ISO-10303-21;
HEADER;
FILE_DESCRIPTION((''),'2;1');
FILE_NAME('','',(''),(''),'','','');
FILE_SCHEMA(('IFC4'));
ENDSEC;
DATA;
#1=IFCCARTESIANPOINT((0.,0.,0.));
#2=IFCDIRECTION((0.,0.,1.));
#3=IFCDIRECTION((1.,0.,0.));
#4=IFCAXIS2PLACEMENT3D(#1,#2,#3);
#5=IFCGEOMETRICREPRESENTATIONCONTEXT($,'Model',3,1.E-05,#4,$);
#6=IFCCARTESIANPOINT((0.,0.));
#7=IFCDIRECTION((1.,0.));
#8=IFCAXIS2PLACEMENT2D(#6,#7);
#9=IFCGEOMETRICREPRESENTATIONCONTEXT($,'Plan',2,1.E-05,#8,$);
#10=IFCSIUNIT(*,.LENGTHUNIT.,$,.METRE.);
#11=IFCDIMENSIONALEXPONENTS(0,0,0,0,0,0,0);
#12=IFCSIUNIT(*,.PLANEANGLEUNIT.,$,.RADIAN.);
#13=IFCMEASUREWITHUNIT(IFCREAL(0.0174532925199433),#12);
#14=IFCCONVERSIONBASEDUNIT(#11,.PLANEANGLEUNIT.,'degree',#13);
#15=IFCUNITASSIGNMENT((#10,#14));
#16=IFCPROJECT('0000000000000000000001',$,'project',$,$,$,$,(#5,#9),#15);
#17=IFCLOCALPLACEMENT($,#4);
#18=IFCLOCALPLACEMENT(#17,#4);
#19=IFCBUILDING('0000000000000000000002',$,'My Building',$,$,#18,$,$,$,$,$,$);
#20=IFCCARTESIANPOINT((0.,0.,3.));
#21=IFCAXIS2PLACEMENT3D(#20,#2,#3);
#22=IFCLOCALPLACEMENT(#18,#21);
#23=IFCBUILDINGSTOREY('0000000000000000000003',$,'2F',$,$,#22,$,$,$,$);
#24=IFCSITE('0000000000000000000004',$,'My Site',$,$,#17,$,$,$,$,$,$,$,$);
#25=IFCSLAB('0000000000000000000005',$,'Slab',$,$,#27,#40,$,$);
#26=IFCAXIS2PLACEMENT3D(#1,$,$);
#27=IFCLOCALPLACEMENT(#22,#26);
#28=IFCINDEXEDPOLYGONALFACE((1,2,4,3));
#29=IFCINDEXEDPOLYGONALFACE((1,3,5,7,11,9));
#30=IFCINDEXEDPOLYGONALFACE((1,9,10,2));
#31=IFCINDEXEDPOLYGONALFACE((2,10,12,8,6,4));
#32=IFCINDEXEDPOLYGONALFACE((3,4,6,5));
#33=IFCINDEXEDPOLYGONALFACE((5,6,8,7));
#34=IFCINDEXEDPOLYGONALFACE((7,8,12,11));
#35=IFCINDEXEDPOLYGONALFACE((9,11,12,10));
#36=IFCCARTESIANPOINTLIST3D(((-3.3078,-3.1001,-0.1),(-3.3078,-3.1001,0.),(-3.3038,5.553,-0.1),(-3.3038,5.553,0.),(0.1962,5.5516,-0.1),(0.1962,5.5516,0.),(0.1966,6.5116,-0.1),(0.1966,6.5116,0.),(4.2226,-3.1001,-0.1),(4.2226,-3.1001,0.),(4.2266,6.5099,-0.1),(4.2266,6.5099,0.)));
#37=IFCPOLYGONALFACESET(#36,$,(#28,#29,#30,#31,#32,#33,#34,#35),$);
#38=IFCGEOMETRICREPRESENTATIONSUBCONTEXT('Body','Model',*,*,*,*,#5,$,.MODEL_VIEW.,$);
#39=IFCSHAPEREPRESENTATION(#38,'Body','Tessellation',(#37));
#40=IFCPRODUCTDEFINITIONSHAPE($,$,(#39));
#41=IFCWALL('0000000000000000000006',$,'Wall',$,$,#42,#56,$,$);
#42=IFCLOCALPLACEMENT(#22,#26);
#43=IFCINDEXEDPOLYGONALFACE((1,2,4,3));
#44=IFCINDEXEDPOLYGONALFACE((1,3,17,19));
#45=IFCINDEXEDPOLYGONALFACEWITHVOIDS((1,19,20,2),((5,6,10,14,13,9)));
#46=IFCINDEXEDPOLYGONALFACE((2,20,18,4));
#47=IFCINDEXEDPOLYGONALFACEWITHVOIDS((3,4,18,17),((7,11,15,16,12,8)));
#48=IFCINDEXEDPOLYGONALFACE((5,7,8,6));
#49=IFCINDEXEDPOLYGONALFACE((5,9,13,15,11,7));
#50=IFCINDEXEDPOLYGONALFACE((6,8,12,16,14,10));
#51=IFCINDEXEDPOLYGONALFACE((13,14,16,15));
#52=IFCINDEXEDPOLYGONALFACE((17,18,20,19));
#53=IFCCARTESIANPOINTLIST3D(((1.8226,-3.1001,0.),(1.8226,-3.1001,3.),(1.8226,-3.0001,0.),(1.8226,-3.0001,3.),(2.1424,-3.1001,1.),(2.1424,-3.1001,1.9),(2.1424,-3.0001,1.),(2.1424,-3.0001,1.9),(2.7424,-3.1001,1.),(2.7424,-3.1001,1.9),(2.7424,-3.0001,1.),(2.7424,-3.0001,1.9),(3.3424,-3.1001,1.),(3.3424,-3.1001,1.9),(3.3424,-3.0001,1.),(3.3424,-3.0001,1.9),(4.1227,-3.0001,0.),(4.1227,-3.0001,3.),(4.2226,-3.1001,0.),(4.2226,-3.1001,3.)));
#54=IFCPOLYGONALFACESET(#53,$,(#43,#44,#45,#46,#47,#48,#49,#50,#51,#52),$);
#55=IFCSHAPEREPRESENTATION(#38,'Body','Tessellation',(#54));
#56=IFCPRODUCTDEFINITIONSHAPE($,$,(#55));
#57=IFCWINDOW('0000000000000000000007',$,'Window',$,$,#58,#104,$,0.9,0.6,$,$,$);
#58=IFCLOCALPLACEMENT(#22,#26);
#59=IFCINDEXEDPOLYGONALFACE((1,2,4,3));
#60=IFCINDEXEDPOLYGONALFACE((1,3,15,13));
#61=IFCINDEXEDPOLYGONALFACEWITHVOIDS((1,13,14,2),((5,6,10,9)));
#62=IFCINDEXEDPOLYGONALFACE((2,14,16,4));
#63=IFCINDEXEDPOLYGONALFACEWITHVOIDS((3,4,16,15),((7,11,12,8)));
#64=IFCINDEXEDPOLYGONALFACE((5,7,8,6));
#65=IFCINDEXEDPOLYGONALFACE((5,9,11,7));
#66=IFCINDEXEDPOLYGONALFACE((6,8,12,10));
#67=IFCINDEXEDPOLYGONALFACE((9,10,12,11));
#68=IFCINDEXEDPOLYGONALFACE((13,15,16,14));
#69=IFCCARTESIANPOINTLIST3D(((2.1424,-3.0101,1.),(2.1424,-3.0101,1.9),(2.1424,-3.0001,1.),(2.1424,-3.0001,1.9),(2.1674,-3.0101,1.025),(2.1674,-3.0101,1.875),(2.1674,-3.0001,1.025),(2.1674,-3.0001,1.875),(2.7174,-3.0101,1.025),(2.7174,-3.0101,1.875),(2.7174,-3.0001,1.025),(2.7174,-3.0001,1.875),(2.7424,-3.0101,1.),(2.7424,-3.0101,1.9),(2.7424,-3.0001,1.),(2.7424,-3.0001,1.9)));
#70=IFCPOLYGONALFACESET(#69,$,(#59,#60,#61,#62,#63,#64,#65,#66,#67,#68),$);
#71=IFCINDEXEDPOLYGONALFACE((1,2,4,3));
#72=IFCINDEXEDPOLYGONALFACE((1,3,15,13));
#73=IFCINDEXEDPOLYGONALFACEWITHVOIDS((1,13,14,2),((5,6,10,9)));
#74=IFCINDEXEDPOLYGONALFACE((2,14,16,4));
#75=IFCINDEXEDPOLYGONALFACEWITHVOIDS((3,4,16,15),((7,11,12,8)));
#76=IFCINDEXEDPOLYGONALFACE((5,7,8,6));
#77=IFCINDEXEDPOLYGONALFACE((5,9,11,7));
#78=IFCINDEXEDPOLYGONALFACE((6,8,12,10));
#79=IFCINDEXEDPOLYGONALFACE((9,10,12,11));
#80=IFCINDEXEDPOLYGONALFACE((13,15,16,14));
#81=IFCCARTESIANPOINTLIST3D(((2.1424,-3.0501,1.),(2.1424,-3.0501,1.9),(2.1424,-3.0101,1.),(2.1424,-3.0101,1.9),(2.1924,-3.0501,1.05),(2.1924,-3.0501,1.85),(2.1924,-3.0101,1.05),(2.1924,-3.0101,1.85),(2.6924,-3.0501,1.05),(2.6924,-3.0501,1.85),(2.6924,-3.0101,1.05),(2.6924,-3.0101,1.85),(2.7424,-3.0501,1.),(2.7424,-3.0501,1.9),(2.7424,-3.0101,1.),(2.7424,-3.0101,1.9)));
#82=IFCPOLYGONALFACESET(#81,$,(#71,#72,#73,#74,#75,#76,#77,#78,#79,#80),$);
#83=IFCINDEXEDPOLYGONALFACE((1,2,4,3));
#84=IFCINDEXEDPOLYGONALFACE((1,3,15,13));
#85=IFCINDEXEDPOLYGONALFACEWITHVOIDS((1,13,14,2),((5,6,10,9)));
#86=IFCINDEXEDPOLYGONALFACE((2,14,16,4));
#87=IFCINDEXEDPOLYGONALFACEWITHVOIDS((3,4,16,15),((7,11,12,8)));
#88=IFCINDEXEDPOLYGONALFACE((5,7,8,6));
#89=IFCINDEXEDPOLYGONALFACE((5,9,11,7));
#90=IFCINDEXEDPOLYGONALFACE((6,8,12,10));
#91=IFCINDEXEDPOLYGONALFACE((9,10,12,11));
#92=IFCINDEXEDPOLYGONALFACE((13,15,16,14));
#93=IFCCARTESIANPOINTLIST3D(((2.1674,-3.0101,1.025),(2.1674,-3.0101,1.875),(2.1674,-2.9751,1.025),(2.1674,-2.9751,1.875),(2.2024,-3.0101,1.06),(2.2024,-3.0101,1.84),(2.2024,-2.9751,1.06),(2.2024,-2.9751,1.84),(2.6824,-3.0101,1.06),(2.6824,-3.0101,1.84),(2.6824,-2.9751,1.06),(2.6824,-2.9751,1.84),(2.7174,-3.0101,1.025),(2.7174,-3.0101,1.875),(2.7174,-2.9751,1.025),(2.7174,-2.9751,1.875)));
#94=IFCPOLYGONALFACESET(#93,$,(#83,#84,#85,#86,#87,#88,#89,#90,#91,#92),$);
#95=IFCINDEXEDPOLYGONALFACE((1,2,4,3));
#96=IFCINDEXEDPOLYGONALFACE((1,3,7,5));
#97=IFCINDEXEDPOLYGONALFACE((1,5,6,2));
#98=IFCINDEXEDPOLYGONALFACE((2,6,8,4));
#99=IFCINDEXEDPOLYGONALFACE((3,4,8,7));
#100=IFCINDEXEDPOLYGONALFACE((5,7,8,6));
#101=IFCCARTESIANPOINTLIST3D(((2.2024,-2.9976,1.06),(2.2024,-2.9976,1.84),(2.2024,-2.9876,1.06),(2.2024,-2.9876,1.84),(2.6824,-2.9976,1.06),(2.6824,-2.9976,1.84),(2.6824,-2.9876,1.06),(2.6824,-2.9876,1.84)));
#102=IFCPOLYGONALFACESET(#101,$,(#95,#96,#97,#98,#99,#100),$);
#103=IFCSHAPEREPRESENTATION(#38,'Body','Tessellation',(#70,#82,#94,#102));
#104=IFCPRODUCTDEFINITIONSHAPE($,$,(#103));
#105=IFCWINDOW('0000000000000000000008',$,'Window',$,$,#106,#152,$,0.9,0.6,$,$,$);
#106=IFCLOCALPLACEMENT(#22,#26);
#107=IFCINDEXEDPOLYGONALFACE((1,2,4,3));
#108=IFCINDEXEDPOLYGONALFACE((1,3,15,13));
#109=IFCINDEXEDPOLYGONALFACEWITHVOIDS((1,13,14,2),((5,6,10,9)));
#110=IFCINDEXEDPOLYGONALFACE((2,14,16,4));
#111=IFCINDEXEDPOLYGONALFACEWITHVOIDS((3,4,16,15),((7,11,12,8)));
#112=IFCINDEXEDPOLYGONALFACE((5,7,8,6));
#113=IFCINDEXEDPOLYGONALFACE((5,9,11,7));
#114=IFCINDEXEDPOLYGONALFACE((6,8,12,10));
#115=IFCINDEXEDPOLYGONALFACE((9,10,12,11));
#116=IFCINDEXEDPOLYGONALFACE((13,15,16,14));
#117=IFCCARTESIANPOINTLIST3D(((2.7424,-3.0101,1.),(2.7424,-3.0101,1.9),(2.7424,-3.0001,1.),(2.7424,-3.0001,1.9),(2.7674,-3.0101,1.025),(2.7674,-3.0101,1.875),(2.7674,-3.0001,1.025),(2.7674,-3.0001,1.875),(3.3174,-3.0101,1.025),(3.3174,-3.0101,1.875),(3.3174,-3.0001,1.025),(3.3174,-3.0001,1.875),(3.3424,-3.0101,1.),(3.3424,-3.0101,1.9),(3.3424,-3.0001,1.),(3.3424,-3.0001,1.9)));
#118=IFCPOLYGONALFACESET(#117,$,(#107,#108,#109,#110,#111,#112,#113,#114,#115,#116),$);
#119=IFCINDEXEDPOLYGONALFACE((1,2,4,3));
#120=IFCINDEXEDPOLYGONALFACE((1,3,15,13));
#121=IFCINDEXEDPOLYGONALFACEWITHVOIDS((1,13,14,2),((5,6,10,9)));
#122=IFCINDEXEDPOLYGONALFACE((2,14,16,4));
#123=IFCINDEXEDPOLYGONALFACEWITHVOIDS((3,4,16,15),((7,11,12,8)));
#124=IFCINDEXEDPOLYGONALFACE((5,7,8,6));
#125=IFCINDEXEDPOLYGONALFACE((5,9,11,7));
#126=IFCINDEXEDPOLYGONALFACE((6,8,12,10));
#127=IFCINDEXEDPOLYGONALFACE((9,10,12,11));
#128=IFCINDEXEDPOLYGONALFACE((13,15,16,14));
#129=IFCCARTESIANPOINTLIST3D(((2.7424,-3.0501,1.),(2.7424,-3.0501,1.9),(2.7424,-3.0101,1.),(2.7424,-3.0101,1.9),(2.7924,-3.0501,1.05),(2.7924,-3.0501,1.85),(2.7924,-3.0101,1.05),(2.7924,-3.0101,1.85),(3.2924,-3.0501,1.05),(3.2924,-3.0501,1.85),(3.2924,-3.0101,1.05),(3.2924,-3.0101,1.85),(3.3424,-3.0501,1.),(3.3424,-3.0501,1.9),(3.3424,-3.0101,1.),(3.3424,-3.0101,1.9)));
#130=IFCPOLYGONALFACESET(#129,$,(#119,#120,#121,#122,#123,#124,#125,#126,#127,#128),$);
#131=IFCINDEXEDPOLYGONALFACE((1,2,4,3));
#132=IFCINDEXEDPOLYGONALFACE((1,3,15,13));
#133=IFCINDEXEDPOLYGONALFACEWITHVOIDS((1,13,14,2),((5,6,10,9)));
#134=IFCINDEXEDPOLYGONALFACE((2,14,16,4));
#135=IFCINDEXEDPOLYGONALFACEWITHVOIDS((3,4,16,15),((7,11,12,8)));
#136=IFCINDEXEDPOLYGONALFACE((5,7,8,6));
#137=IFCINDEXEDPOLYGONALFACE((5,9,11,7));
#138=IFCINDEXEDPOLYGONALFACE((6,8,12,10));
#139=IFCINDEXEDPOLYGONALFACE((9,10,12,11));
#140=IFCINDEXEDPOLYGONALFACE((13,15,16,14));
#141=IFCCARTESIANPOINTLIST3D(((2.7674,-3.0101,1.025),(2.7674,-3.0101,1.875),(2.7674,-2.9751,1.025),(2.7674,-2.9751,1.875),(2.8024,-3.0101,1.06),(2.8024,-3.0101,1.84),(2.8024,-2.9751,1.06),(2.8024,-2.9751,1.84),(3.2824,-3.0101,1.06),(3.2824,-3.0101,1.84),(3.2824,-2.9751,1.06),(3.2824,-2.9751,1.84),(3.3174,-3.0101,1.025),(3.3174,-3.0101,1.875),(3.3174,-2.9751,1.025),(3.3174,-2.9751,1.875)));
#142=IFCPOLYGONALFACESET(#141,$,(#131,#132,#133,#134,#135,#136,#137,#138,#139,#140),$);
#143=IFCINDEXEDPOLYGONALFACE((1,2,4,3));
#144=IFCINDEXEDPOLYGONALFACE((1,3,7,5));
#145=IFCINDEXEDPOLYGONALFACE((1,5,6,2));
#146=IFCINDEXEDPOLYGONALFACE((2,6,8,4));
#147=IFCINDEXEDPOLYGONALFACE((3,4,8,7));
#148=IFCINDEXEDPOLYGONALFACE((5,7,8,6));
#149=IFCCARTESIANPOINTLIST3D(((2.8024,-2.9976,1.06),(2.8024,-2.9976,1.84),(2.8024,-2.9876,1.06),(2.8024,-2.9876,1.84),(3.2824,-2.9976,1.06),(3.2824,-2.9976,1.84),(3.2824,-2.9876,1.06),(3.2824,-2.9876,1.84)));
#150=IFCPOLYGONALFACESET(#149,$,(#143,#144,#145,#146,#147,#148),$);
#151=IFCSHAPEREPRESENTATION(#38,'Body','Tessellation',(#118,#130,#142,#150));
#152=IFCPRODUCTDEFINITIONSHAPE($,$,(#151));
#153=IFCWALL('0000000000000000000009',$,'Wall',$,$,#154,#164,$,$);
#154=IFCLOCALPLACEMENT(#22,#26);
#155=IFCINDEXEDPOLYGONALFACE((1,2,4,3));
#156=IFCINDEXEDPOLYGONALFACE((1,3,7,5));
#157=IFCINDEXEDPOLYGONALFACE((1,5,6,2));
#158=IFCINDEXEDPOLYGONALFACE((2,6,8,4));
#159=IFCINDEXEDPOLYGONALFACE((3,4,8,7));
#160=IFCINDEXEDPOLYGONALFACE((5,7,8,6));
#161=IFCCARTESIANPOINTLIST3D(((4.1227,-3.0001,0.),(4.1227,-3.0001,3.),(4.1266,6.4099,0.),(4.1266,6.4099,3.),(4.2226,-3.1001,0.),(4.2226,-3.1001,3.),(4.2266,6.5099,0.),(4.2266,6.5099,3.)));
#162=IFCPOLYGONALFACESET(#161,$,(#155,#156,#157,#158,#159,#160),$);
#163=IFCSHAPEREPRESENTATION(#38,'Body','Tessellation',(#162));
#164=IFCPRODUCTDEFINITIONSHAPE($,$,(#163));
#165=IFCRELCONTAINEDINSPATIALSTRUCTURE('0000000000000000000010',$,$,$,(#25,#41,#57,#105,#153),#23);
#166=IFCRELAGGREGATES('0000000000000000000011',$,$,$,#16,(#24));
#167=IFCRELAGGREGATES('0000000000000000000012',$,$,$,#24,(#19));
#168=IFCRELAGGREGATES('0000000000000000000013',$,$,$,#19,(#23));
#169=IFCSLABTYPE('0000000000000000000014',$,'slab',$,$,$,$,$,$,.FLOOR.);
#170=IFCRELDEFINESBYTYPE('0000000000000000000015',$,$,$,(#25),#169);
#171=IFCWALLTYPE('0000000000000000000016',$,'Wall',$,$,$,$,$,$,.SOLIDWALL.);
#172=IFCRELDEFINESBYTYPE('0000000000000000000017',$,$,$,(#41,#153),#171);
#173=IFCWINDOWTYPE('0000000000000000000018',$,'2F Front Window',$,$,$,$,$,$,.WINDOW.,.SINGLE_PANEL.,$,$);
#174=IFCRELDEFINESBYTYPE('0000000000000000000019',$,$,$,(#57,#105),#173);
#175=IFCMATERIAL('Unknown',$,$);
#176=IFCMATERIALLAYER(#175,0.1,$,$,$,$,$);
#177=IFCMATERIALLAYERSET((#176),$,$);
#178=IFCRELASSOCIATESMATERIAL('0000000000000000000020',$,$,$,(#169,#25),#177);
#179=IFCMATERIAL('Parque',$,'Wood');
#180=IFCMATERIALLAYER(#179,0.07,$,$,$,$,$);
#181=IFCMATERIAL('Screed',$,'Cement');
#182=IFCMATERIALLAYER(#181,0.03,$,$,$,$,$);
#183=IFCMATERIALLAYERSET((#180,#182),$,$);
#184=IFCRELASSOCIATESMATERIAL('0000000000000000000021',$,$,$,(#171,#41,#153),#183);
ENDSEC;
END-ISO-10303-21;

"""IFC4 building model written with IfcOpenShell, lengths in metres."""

from ifc_helpers import new_model, entity, si_unit, converted_unit, frame, origin_with_axes, origin_2d_with_axis, place, context, subcontext, project, spatial, line, indexed_curve, outline, extrude, shape, source, transform, mapped, material, layer, layer_set, layer_usage, type_object, type_shapes, element, fill, save


model = new_model("IFC4")

# Units and contexts
model_context = context("Model", 3, precision=1e-05, world=origin_with_axes())
plan_context = context("Plan", 2, precision=1e-05, world=origin_2d_with_axis())
body_context_1 = subcontext(model_context, "Body", "Model", "MODEL_VIEW")
body_context_2 = subcontext(plan_context, "Body", "Plan", "PLAN_VIEW")
ifc_project = project(units=[si_unit("LENGTHUNIT", "METRE"), converted_unit("PLANEANGLEUNIT", "degree", entity("IfcReal", 0.0174532925199433), si_unit("PLANEANGLEUNIT", "RADIAN"), dimensions=[0, 0, 0, 0, 0, 0, 0])], contexts=[model_context, plan_context])

# Site, building, storey
site_placement = place(None, origin_with_axes())
site = spatial("IfcSite", under=ifc_project, at=site_placement, Name="My Site")
building_placement = place(site_placement, origin_with_axes())
building = spatial("IfcBuilding", under=site, at=building_placement, Name="My Building")
storey_placement = place(building_placement, frame((0.0, 0.0, 3.0), z_axis=(0.0, 0.0, 1.0), x_axis=(1.0, 0.0, 0.0)))
storey = spatial("IfcBuildingStorey", under=building, at=storey_placement, Name="2F")

# Slab
ifc_material_1 = material(Name="Unknown")
ifc_layer_1 = layer(ifc_material_1, 0.1)
ifc_layer_set_1 = layer_set([ifc_layer_1])
ifc_layer_usage_1 = layer_usage(ifc_layer_set_1, "AXIS3", "POSITIVE", -0.1)
slab_type = type_object("IfcSlabType", Name="slab", PredefinedType="FLOOR", material=ifc_layer_set_1)
slab_placement = place(storey_placement, frame((-3.3078, -3.1001, 0.0), z_axis=(0.0, 0.0, 1.0), x_axis=(1.0, 0.0, 0.0)))
element("IfcSlab", 1, at=slab_placement, inside=storey, type_object=slab_type, material=ifc_layer_usage_1, Name="Slab", context=body_context_1, shape_type="SweptSolid", body=[
    extrude(outline(indexed_curve([(0.0, 0.0), (7.5304, 0.0), (7.5344, 9.61), (3.5044, 9.6117), (3.504, 8.6517), (0.004, 8.6531), (0.0, 0.0)])), frame((0.0, 0.0, -0.1), z_axis=(0.0, 0.0, 1.0), x_axis=(1.0, 0.0, 0.0)), (0.0, 0.0, 1.0), 0.1),
])

# Wall, openings, windows
ifc_material_2 = material(Name="Parque", Category="Wood")
ifc_layer_2 = layer(ifc_material_2, 0.07)
ifc_material_3 = material(Name="Screed", Category="Cement")
ifc_layer_3 = layer(ifc_material_3, 0.03)
ifc_layer_set_2 = layer_set([ifc_layer_2, ifc_layer_3])
ifc_layer_usage_2 = layer_usage(ifc_layer_set_2, "AXIS2", "POSITIVE", 0.0)
wall_type = type_object("IfcWallType", Name="Wall", PredefinedType="SOLIDWALL", material=ifc_layer_set_2)
wall_1_placement = place(storey_placement, frame((1.8226, -3.1001, 0.0), z_axis=(0.0, 0.0, 1.0), x_axis=(1.0, 0.0, 0.0)))
wall_1 = element("IfcWall", 2, at=wall_1_placement, inside=storey, type_object=wall_type, material=ifc_layer_usage_2, Name="Wall", context=body_context_1, shape_type="SweptSolid", body=[
    extrude(outline(indexed_curve([(0.0, 0.0), (0.0, 0.1), (2.3, 0.1), (2.4, 0.0)], segments=[line(1, 2, 3, 4, 1)])), origin_with_axes(), (0.0, 0.0, 1.0), 3.0),
])
shared_shape_1 = source(origin_with_axes(), body_context_1, "Body", "SweptSolid", [
    extrude(outline(indexed_curve([(0.0, 0.0), (0.6, 0.0), (0.6, 0.9), (0.0, 0.9)], segments=[line(1, 2, 3, 4, 1)])), frame((0.0, -0.6, 0.0), z_axis=(0.0, -1.0, 0.0), x_axis=(1.0, 0.0, 0.0)), (0.0, 0.0, -1.0), 1.2),
])
opening_1_placement = place(wall_1_placement, frame((0.3197, 0.0, 1.0), z_axis=(0.0, 0.0, 1.0), x_axis=(1.0, 0.0, 0.0)))
opening_1 = element("IfcOpeningElement", 3, at=opening_1_placement, cuts=wall_1, PredefinedType="OPENING", context=body_context_1, shape_type="MappedRepresentation", body=[
    mapped(shared_shape_1, transform((0.0, 0.0, 0.0), x_axis=(1.0, 0.0, 0.0), y_axis=(0.0, 1.0, 0.0), z_axis=(0.0, 0.0, 1.0), scale=1.0)),
])
opening_2_placement = place(wall_1_placement, frame((0.9197, 0.0, 1.0), z_axis=(0.0, 0.0, 1.0), x_axis=(1.0, 0.0, 0.0)))
opening_2 = element("IfcOpeningElement", 4, at=opening_2_placement, cuts=wall_1, PredefinedType="OPENING", context=body_context_1, shape_type="MappedRepresentation", body=[
    mapped(shared_shape_1, transform((0.0, 0.0, 0.0), x_axis=(1.0, 0.0, 0.0), y_axis=(0.0, 1.0, 0.0), z_axis=(0.0, 0.0, 1.0), scale=1.0)),
])
window_type = type_object("IfcWindowType", Name="2F Front Window", PartitioningType="SINGLE_PANEL", PredefinedType="WINDOW")
shared_shape_2 = source(origin_with_axes(), body_context_1, "Body", "SweptSolid", [
    extrude(outline(indexed_curve([(0.0, 0.0), (0.6, 0.0), (0.6, 0.9), (0.0, 0.9)], segments=[line(1, 2, 3, 4, 1)]), holes=[indexed_curve([(0.025, 0.025), (0.575, 0.025), (0.575, 0.875), (0.025, 0.875)], segments=[line(1, 2, 3, 4, 1)])]), frame((0.0, 0.09, 0.0), z_axis=(0.0, -1.0, 0.0), x_axis=(1.0, 0.0, 0.0)), (0.0, 0.0, -1.0), 0.01),
    extrude(outline(indexed_curve([(0.0, 0.0), (0.6, 0.0), (0.6, 0.9), (0.0, 0.9)], segments=[line(1, 2, 3, 4, 1)]), holes=[indexed_curve([(0.05, 0.05), (0.55, 0.05), (0.55, 0.85), (0.05, 0.85)], segments=[line(1, 2, 3, 4, 1)])]), frame((0.0, 0.05, 0.0), z_axis=(0.0, -1.0, 0.0), x_axis=(1.0, 0.0, 0.0)), (0.0, 0.0, -1.0), 0.04),
    extrude(outline(indexed_curve([(0.0, 0.0), (0.55, 0.0), (0.55, 0.85), (0.0, 0.85)], segments=[line(1, 2, 3, 4, 1)]), holes=[indexed_curve([(0.035, 0.035), (0.515, 0.035), (0.515, 0.815), (0.035, 0.815)], segments=[line(1, 2, 3, 4, 1)])]), frame((0.025, 0.09, 0.025), z_axis=(0.0, -1.0, 0.0), x_axis=(1.0, 0.0, 0.0)), (0.0, 0.0, -1.0), 0.035),
    extrude(outline(indexed_curve([(0.035, 0.035), (0.515, 0.035), (0.515, 0.815), (0.035, 0.815)], segments=[line(1, 2, 3, 4, 1)])), frame((0.025, 0.1025, 0.025), z_axis=(0.0, -1.0, 0.0), x_axis=(1.0, 0.0, 0.0)), (0.0, 0.0, -1.0), 0.01),
])
shared_shape_3 = source(origin_with_axes(), body_context_2, "Body", "Curve2D", [
    entity("IfcIndexedPolyCurve", entity("IfcCartesianPointList2D", [[0.05, 0.05], [0.55, 0.05]])),
    entity("IfcIndexedPolyCurve", entity("IfcCartesianPointList2D", [[0.0, 0.1], [0.025, 0.1], [0.025, 0.09], [0.05, 0.09], [0.05, 0.05], [0.0, 0.05]]), [entity("IfcLineIndex", [1, 2, 3, 4, 5, 6, 1])]),
    entity("IfcIndexedPolyCurve", entity("IfcCartesianPointList2D", [[0.6, 0.1], [0.575, 0.1], [0.575, 0.09], [0.55, 0.09], [0.55, 0.05], [0.6, 0.05]]), [entity("IfcLineIndex", [1, 2, 3, 4, 5, 6, 1])]),
    entity("IfcIndexedPolyCurve", entity("IfcCartesianPointList2D", [[0.025, 0.09], [0.06, 0.09], [0.06, 0.125], [0.025, 0.125]]), [entity("IfcLineIndex", [1, 2, 3, 4, 1])]),
    entity("IfcIndexedPolyCurve", entity("IfcCartesianPointList2D", [[0.575, 0.09], [0.54, 0.09], [0.54, 0.125], [0.575, 0.125]]), [entity("IfcLineIndex", [1, 2, 3, 4, 1])]),
    entity("IfcIndexedPolyCurve", entity("IfcCartesianPointList2D", [[0.06, 0.09], [0.54, 0.09]])),
    entity("IfcIndexedPolyCurve", entity("IfcCartesianPointList2D", [[0.06, 0.125], [0.54, 0.125]])),
    entity("IfcIndexedPolyCurve", entity("IfcCartesianPointList2D", [[0.06, 0.1075], [0.54, 0.1075]])),
])
type_shapes(window_type, [shared_shape_2, shared_shape_3])
window_1_placement = place(opening_1_placement, origin_with_axes())
window_1 = element("IfcWindow", 5, at=window_1_placement, inside=storey, type_object=window_type, Name="Window", OverallHeight=0.9, OverallWidth=0.6, shapes=[
    shape(body_context_1, "Body", "MappedRepresentation", [mapped(shared_shape_2, transform((0.0, 0.0, 0.0), x_axis=(1.0, 0.0, 0.0), y_axis=(0.0, 1.0, 0.0), z_axis=(0.0, 0.0, 1.0), scale=1.0))]),
    shape(body_context_2, "Body", "MappedRepresentation", [mapped(shared_shape_3, transform((0.0, 0.0, 0.0), x_axis=(1.0, 0.0, 0.0), y_axis=(0.0, 1.0, 0.0), z_axis=(0.0, 0.0, 1.0), scale=1.0))]),
])
fill(opening_1, window_1)
window_2_placement = place(opening_2_placement, origin_with_axes())
window_2 = element("IfcWindow", 6, at=window_2_placement, inside=storey, type_object=window_type, Name="Window", OverallHeight=0.9, OverallWidth=0.6, shapes=[
    shape(body_context_1, "Body", "MappedRepresentation", [mapped(shared_shape_2, transform((0.0, 0.0, 0.0), x_axis=(1.0, 0.0, 0.0), y_axis=(0.0, 1.0, 0.0), z_axis=(0.0, 0.0, 1.0), scale=1.0))]),
    shape(body_context_2, "Body", "MappedRepresentation", [mapped(shared_shape_3, transform((0.0, 0.0, 0.0), x_axis=(1.0, 0.0, 0.0), y_axis=(0.0, 1.0, 0.0), z_axis=(0.0, 0.0, 1.0), scale=1.0))]),
])
fill(opening_2, window_2)

# Wall
ifc_layer_usage_3 = layer_usage(ifc_layer_set_2, "AXIS2", "POSITIVE", 0.0)
wall_2_placement = place(storey_placement, frame((4.2226, -3.1001, 0.0), z_axis=(0.0, 0.0, 1.0), x_axis=(0.000415, 1.0, 0.0)))
element("IfcWall", 7, at=wall_2_placement, inside=storey, type_object=wall_type, material=ifc_layer_usage_3, Name="Wall", context=body_context_1, shape_type="SweptSolid", body=[
    extrude(outline(indexed_curve([(0.0, 0.0), (0.1, 0.1), (9.51, 0.1), (9.61, 0.0)], segments=[line(1, 2, 3, 4, 1)])), origin_with_axes(), (0.0, 0.0, 1.0), 3.0),
])

save(model, "model.ifc")
